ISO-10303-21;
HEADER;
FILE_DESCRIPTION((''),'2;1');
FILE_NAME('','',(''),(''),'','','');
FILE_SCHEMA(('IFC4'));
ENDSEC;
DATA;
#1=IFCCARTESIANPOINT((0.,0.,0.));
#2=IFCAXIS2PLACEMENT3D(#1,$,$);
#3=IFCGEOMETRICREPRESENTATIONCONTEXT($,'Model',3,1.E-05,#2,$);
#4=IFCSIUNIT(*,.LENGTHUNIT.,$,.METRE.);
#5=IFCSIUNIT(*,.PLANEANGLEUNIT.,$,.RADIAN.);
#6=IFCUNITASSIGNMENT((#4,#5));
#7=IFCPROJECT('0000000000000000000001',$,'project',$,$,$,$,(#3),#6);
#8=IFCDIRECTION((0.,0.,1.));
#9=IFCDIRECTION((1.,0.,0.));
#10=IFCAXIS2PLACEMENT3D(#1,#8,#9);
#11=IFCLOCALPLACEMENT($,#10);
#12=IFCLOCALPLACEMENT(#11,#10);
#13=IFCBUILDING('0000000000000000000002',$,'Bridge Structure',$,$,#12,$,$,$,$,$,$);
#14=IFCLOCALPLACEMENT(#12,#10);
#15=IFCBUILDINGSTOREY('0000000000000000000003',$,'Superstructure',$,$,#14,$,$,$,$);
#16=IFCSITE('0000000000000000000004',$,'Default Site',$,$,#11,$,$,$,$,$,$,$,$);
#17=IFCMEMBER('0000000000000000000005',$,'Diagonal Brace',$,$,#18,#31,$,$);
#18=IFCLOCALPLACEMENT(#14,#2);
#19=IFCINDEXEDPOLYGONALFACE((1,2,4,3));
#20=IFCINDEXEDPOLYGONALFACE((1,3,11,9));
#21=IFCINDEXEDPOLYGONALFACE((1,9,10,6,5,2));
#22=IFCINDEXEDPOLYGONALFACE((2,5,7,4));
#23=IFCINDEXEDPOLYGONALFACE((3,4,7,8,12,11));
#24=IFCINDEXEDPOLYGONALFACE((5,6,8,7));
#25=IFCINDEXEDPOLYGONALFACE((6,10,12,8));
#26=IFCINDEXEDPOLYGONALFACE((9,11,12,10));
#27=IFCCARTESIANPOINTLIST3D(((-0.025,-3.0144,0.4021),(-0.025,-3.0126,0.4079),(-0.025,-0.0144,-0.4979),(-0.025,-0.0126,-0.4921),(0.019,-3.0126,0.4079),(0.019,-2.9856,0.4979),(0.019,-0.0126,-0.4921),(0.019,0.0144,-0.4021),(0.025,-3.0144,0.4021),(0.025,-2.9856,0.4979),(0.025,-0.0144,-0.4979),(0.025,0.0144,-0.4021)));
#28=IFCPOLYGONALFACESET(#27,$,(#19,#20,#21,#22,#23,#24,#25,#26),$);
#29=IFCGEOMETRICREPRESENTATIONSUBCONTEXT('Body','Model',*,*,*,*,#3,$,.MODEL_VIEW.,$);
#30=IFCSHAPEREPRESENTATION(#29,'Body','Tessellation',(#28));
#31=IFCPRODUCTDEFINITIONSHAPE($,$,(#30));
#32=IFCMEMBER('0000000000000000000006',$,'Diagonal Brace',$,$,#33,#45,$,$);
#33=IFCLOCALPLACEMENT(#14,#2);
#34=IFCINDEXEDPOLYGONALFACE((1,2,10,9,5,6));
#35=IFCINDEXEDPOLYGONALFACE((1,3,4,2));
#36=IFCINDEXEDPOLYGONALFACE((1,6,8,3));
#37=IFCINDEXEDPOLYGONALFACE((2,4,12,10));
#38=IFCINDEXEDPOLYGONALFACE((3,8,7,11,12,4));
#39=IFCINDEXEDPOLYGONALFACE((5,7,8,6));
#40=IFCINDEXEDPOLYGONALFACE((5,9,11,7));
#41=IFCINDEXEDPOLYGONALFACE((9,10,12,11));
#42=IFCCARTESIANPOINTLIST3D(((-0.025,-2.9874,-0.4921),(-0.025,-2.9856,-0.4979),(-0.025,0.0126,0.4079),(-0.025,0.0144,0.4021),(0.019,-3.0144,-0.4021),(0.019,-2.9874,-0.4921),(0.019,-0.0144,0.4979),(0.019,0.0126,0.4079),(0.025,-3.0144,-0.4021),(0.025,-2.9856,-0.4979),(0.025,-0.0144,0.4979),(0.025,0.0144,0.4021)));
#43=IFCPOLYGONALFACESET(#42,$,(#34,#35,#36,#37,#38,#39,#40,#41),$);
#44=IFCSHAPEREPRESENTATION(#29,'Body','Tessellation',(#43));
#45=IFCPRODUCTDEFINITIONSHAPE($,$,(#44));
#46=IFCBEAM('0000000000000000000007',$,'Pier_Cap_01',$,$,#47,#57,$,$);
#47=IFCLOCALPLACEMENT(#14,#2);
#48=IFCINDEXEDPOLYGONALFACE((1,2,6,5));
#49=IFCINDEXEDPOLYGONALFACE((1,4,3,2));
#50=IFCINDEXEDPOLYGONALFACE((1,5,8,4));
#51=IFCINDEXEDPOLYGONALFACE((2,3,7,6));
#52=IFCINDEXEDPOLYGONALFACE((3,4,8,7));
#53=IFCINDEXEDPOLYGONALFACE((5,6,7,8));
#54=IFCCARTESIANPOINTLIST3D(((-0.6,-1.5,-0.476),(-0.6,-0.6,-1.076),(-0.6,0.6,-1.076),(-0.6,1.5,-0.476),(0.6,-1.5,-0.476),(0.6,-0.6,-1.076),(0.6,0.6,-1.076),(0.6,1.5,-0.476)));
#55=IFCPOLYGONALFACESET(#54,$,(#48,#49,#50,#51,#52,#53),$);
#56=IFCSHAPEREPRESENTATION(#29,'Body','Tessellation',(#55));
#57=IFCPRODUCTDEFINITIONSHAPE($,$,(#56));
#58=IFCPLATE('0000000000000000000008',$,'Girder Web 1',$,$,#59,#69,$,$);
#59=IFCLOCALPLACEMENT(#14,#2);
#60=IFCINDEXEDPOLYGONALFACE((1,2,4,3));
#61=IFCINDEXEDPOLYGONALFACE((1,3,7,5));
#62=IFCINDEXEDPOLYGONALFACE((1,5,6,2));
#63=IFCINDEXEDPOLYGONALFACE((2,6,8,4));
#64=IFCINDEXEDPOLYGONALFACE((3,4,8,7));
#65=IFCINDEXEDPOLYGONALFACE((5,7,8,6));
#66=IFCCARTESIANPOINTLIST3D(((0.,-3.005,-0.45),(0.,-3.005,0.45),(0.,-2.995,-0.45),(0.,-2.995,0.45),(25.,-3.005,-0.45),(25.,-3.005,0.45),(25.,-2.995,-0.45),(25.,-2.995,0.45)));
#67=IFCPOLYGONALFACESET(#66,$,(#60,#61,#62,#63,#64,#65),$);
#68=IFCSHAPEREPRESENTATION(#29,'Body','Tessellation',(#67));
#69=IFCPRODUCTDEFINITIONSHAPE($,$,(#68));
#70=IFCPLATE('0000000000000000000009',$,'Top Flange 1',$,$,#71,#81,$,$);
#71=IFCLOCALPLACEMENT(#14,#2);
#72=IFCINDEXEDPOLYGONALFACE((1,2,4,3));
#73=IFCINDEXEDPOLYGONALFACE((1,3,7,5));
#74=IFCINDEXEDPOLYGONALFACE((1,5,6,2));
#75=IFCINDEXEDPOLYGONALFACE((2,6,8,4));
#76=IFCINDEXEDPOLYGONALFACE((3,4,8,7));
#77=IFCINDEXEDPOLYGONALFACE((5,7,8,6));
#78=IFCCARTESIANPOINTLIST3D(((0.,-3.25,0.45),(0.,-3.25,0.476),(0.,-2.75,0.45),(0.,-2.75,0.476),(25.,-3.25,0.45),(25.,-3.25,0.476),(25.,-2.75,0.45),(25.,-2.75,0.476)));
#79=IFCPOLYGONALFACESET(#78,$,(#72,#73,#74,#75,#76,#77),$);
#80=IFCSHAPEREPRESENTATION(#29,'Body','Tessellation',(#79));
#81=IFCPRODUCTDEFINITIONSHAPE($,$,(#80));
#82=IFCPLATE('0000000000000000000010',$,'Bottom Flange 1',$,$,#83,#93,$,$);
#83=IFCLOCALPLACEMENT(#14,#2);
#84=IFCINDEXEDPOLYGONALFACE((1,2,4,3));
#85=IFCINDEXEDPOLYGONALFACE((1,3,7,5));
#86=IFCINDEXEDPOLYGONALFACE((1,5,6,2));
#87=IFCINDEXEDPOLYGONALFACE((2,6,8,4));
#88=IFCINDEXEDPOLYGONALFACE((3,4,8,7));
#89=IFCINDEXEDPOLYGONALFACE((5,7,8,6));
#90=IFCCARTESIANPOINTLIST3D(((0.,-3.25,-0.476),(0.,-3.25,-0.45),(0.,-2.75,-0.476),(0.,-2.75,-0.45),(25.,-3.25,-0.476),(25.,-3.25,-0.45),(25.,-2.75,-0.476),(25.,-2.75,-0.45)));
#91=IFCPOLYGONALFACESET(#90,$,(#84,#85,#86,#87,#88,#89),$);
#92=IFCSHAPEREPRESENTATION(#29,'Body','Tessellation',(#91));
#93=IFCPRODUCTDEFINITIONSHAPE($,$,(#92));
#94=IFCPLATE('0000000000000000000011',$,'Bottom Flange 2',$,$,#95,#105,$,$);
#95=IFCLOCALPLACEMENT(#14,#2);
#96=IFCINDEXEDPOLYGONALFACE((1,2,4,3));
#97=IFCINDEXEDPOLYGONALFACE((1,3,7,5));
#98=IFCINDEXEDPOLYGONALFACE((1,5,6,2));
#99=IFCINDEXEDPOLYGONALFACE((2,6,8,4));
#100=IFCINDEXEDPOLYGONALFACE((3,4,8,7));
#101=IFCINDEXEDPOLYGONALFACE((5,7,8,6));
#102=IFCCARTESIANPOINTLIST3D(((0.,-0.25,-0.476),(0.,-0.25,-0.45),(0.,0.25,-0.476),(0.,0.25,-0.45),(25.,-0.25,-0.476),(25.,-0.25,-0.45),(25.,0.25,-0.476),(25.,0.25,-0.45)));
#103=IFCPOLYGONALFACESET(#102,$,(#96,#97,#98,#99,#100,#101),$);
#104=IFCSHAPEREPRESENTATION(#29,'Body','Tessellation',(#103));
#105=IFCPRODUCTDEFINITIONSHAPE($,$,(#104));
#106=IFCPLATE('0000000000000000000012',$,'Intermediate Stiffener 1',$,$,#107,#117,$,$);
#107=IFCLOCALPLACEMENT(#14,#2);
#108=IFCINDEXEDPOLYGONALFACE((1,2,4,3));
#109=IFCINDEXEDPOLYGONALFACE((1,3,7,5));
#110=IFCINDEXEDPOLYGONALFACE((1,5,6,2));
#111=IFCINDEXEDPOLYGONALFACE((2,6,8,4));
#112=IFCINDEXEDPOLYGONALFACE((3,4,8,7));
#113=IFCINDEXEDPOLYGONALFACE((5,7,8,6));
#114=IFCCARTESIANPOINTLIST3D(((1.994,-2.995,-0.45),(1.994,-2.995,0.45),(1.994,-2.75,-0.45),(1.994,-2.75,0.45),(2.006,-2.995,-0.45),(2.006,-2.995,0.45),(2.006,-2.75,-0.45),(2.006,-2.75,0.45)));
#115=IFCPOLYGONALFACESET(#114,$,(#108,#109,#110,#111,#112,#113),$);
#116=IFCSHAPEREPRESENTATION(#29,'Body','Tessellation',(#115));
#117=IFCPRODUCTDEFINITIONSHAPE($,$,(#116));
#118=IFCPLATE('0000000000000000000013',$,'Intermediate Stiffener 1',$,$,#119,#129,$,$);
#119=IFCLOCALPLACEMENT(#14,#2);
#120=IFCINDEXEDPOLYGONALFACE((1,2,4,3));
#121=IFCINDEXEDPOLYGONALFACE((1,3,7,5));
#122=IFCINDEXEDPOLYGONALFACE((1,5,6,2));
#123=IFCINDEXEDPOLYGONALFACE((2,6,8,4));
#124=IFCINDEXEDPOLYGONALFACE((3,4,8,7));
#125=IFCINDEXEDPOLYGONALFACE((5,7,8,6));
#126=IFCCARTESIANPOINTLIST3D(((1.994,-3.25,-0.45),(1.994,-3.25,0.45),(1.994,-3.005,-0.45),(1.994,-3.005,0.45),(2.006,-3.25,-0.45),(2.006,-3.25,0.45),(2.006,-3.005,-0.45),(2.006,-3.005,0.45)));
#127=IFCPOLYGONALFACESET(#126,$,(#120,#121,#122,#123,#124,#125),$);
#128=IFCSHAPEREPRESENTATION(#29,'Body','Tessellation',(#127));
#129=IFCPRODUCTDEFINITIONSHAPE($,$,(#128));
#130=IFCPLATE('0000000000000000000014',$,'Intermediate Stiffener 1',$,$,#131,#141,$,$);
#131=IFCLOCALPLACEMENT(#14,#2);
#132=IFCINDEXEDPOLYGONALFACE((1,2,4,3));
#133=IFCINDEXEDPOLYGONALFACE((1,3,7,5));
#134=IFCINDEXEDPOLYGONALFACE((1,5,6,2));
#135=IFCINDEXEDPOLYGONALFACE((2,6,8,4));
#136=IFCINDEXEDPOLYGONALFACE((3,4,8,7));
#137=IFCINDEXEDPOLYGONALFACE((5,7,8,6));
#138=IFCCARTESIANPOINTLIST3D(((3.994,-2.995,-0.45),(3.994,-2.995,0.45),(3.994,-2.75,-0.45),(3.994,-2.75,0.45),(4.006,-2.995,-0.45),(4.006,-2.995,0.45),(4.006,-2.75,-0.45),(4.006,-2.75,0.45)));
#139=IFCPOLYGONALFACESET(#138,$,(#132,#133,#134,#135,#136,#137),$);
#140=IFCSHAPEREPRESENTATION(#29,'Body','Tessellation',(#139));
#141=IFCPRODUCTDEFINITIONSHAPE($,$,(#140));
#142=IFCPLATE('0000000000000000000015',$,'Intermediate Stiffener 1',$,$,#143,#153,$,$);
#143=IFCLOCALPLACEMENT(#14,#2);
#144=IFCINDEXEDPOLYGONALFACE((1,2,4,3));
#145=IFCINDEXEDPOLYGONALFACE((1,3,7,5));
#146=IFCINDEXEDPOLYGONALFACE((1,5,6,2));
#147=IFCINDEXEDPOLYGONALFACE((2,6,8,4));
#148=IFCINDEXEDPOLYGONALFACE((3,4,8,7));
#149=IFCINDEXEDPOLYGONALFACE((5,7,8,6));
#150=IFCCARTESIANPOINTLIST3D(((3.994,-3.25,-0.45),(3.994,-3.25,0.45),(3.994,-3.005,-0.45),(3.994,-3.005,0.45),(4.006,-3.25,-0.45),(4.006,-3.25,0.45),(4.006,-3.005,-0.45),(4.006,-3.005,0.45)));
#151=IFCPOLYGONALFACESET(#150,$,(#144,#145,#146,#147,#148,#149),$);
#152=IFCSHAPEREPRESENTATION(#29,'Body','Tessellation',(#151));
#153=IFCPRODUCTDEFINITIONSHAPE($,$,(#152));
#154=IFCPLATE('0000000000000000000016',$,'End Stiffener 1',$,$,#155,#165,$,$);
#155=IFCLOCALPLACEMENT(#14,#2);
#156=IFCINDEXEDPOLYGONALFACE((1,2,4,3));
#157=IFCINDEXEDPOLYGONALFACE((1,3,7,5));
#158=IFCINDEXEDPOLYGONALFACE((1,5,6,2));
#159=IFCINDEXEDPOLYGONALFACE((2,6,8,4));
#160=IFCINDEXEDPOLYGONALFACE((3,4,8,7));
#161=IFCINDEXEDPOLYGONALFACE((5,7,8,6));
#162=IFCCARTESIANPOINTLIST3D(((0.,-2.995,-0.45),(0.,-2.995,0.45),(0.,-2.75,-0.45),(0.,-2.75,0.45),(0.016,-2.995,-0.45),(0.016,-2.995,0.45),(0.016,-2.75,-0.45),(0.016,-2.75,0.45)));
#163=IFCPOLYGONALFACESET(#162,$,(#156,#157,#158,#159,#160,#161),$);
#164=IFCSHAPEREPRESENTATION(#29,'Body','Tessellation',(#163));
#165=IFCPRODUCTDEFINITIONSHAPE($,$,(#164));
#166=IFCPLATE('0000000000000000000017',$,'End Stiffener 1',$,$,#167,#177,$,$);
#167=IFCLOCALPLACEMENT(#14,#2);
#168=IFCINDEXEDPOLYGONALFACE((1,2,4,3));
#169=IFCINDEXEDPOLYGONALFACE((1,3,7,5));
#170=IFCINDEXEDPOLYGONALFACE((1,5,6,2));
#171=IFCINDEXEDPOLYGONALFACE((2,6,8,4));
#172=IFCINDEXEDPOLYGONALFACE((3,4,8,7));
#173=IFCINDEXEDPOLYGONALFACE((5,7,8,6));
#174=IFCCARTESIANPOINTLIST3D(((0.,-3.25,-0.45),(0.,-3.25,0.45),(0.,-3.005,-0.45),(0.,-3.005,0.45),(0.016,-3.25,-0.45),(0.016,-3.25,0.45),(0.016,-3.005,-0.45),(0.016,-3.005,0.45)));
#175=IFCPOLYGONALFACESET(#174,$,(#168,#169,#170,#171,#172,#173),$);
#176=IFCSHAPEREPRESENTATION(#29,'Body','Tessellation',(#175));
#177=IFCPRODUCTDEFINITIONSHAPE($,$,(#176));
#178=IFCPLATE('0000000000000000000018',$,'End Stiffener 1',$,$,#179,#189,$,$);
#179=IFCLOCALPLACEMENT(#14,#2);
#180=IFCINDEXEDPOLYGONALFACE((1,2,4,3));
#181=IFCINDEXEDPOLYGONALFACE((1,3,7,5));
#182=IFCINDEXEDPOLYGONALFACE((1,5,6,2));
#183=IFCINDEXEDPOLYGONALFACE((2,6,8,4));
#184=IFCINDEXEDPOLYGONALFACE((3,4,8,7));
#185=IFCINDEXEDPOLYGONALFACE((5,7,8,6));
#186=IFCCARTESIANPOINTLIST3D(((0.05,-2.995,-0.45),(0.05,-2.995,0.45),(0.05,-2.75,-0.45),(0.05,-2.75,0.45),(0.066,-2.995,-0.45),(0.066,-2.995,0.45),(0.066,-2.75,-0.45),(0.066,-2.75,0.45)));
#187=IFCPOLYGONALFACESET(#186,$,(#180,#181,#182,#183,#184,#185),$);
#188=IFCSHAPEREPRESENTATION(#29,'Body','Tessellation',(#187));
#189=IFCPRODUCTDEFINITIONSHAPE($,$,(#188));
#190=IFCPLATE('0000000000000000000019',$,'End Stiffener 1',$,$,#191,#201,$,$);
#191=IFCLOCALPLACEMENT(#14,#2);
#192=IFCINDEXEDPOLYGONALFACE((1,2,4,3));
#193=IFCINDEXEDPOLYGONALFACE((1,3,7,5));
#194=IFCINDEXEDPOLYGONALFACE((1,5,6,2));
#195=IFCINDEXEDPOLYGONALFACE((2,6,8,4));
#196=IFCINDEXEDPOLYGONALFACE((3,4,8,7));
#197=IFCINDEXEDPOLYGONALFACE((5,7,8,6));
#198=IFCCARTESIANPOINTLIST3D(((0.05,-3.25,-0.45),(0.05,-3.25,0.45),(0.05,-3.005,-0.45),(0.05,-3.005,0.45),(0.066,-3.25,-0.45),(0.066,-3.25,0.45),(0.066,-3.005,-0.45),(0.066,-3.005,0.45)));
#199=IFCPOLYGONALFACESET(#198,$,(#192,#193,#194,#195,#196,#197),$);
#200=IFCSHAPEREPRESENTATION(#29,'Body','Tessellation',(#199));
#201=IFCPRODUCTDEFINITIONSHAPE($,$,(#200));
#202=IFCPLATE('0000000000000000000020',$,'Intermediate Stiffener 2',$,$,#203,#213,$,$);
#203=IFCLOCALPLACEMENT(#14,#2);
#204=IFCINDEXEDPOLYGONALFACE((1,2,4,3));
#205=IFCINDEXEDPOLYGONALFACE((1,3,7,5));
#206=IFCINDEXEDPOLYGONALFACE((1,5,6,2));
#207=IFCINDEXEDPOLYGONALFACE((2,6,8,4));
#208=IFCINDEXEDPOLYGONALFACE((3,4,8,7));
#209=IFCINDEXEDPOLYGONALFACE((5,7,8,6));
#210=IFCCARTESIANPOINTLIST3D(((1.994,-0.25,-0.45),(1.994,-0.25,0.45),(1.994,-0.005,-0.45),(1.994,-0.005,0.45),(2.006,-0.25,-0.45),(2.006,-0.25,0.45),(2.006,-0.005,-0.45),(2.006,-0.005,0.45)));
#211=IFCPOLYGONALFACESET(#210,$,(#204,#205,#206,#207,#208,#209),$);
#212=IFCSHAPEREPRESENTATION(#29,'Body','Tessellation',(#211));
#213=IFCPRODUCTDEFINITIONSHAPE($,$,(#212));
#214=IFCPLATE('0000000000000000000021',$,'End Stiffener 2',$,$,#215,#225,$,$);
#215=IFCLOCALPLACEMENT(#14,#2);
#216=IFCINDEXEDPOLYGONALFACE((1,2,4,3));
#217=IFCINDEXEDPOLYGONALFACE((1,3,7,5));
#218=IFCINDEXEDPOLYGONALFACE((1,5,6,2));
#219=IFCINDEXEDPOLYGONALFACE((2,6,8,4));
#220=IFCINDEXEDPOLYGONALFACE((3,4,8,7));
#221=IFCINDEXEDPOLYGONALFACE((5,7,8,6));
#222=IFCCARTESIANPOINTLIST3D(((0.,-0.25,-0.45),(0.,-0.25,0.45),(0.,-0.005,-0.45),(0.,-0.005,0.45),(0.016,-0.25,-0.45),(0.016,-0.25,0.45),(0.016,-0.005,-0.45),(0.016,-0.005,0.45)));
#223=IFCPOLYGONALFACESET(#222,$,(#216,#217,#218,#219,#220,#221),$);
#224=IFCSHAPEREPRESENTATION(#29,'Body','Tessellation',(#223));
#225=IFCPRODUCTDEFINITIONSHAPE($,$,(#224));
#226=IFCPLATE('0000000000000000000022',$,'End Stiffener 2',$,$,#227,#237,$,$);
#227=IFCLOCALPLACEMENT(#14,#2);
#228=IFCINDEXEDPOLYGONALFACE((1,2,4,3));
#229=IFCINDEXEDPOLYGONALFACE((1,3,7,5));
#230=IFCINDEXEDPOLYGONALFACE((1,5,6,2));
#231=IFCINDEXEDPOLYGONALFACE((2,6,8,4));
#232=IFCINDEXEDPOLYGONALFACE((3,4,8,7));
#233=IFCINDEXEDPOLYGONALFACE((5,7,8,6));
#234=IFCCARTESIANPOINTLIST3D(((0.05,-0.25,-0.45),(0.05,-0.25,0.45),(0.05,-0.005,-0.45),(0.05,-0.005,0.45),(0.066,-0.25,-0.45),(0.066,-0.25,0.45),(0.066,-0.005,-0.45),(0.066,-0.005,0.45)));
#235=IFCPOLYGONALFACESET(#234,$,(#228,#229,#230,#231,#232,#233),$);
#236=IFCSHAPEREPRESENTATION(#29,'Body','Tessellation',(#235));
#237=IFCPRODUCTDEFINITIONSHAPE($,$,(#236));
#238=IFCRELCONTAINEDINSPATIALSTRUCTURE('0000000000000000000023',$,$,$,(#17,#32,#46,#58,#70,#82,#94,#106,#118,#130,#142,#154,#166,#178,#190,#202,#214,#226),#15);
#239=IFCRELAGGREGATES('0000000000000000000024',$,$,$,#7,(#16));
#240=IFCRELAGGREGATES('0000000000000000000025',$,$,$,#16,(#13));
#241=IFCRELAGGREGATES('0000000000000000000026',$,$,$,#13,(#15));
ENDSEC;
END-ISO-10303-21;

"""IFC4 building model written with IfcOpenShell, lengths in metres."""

from ifc_helpers import new_model, si_unit, frame, origin, origin_with_axes, origin_2d_with_axis, place, context, subcontext, project, spatial, polyline, rectangle, l_section, outline, extrude, element, save


model = new_model("IFC4")

# Units and contexts
model_context = context("Model", 3, precision=1e-05, world=origin())
body_context = subcontext(model_context, "Body", "Model", "MODEL_VIEW")
ifc_project = project(units=[si_unit("LENGTHUNIT", "METRE"), si_unit("PLANEANGLEUNIT", "RADIAN")], contexts=[model_context])

# Site, building, storey
site_placement = place(None, origin_with_axes())
site = spatial("IfcSite", under=ifc_project, at=site_placement, Name="Default Site")
building_placement = place(site_placement, origin_with_axes())
building = spatial("IfcBuilding", under=site, at=building_placement, Name="Bridge Structure")
storey_placement = place(building_placement, origin_with_axes())
storey = spatial("IfcBuildingStorey", under=building, at=storey_placement, Name="Superstructure")

# Members
for number, where, z_axis, x_axis, name in (
    (1, (0.0, -3.0, 0.45), (0.0, 0.957826, -0.287348), (-1.0, 0.0, 0.0), "Diagonal Brace"),
    (2, (0.0, -3.0, -0.45), (0.0, 0.957826, 0.287348), (-1.0, 0.0, 0.0), "Diagonal Brace"),
):
    element("IfcMember", number, at=place(storey_placement, frame(where, z_axis=z_axis, x_axis=x_axis)), inside=storey, Name=name, context=body_context, shape_type="SweptSolid", body=[
        extrude(l_section(Depth=0.1, Width=0.05, Thickness=0.006, at=origin_2d_with_axis()), origin_with_axes(), (0.0, 0.0, 1.0), 3.1321),
    ])

# Beam
beam_placement = place(storey_placement, frame((-0.6, 0.0, -0.476), z_axis=(1.0, 0.0, 0.0), x_axis=(0.0, 1.0, 0.0)))
element("IfcBeam", 3, at=beam_placement, inside=storey, Name="Pier_Cap_01", context=body_context, shape_type="SweptSolid", body=[
    extrude(outline(polyline([(-0.6, -0.6), (0.6, -0.6), (1.5, 0.0), (-1.5, 0.0), (-0.6, -0.6)])), origin_with_axes(), (0.0, 0.0, 1.0), 1.2),
])

# Plates
plate_1_placement = place(storey_placement, frame((0.0, -3.0, 0.0), z_axis=(1.0, 0.0, 0.0), x_axis=(0.0, 1.0, 0.0)))
element("IfcPlate", 4, at=plate_1_placement, inside=storey, Name="Girder Web 1", context=body_context, shape_type="SweptSolid", body=[
    extrude(rectangle(XDim=0.01, YDim=0.9, at=origin_2d_with_axis()), origin_with_axes(), (0.0, 0.0, 1.0), 25.0),
])
for number, where, z_axis, x_axis, name in (
    (5, (0.0, -3.0, 0.463), (1.0, 0.0, 0.0), (0.0, 1.0, 0.0), "Top Flange 1"),
    (6, (0.0, -3.0, -0.463), (1.0, 0.0, 0.0), (0.0, 1.0, 0.0), "Bottom Flange 1"),
    (7, (0.0, 0.0, -0.463), (1.0, 0.0, 0.0), (0.0, 1.0, 0.0), "Bottom Flange 2"),
):
    element("IfcPlate", number, at=place(storey_placement, frame(where, z_axis=z_axis, x_axis=x_axis)), inside=storey, Name=name, context=body_context, shape_type="SweptSolid", body=[
        extrude(rectangle(XDim=0.5, YDim=0.026, at=origin_2d_with_axis()), origin_with_axes(), (0.0, 0.0, 1.0), 25.0),
    ])
for number, where, z_axis, x_axis, name in (
    (8, (2.0, -2.8725, -0.45), (0.0, 0.0, 1.0), (1.0, 0.0, 0.0), "Intermediate Stiffener 1"),
    (9, (2.0, -3.1275, -0.45), (0.0, 0.0, 1.0), (1.0, 0.0, 0.0), "Intermediate Stiffener 1"),
    (10, (4.0, -2.8725, -0.45), (0.0, 0.0, 1.0), (1.0, 0.0, 0.0), "Intermediate Stiffener 1"),
    (11, (4.0, -3.1275, -0.45), (0.0, 0.0, 1.0), (1.0, 0.0, 0.0), "Intermediate Stiffener 1"),
):
    element("IfcPlate", number, at=place(storey_placement, frame(where, z_axis=z_axis, x_axis=x_axis)), inside=storey, Name=name, context=body_context, shape_type="SweptSolid", body=[
        extrude(rectangle(XDim=0.012, YDim=0.245, at=origin_2d_with_axis()), origin_with_axes(), (0.0, 0.0, 1.0), 0.9),
    ])
for number, where, z_axis, x_axis, name in (
    (12, (0.008, -2.8725, -0.45), (0.0, 0.0, 1.0), (1.0, 0.0, 0.0), "End Stiffener 1"),
    (13, (0.008, -3.1275, -0.45), (0.0, 0.0, 1.0), (1.0, 0.0, 0.0), "End Stiffener 1"),
    (14, (0.058, -2.8725, -0.45), (0.0, 0.0, 1.0), (1.0, 0.0, 0.0), "End Stiffener 1"),
    (15, (0.058, -3.1275, -0.45), (0.0, 0.0, 1.0), (1.0, 0.0, 0.0), "End Stiffener 1"),
):
    element("IfcPlate", number, at=place(storey_placement, frame(where, z_axis=z_axis, x_axis=x_axis)), inside=storey, Name=name, context=body_context, shape_type="SweptSolid", body=[
        extrude(rectangle(XDim=0.016, YDim=0.245, at=origin_2d_with_axis()), origin_with_axes(), (0.0, 0.0, 1.0), 0.9),
    ])
plate_2_placement = place(storey_placement, frame((2.0, -0.1275, -0.45), z_axis=(0.0, 0.0, 1.0), x_axis=(1.0, 0.0, 0.0)))
element("IfcPlate", 16, at=plate_2_placement, inside=storey, Name="Intermediate Stiffener 2", context=body_context, shape_type="SweptSolid", body=[
    extrude(rectangle(XDim=0.012, YDim=0.245, at=origin_2d_with_axis()), origin_with_axes(), (0.0, 0.0, 1.0), 0.9),
])
for number, where, z_axis, x_axis, name in (
    (17, (0.008, -0.1275, -0.45), (0.0, 0.0, 1.0), (1.0, 0.0, 0.0), "End Stiffener 2"),
    (18, (0.058, -0.1275, -0.45), (0.0, 0.0, 1.0), (1.0, 0.0, 0.0), "End Stiffener 2"),
):
    element("IfcPlate", number, at=place(storey_placement, frame(where, z_axis=z_axis, x_axis=x_axis)), inside=storey, Name=name, context=body_context, shape_type="SweptSolid", body=[
        extrude(rectangle(XDim=0.016, YDim=0.245, at=origin_2d_with_axis()), origin_with_axes(), (0.0, 0.0, 1.0), 0.9),
    ])

save(model, "model.ifc")
